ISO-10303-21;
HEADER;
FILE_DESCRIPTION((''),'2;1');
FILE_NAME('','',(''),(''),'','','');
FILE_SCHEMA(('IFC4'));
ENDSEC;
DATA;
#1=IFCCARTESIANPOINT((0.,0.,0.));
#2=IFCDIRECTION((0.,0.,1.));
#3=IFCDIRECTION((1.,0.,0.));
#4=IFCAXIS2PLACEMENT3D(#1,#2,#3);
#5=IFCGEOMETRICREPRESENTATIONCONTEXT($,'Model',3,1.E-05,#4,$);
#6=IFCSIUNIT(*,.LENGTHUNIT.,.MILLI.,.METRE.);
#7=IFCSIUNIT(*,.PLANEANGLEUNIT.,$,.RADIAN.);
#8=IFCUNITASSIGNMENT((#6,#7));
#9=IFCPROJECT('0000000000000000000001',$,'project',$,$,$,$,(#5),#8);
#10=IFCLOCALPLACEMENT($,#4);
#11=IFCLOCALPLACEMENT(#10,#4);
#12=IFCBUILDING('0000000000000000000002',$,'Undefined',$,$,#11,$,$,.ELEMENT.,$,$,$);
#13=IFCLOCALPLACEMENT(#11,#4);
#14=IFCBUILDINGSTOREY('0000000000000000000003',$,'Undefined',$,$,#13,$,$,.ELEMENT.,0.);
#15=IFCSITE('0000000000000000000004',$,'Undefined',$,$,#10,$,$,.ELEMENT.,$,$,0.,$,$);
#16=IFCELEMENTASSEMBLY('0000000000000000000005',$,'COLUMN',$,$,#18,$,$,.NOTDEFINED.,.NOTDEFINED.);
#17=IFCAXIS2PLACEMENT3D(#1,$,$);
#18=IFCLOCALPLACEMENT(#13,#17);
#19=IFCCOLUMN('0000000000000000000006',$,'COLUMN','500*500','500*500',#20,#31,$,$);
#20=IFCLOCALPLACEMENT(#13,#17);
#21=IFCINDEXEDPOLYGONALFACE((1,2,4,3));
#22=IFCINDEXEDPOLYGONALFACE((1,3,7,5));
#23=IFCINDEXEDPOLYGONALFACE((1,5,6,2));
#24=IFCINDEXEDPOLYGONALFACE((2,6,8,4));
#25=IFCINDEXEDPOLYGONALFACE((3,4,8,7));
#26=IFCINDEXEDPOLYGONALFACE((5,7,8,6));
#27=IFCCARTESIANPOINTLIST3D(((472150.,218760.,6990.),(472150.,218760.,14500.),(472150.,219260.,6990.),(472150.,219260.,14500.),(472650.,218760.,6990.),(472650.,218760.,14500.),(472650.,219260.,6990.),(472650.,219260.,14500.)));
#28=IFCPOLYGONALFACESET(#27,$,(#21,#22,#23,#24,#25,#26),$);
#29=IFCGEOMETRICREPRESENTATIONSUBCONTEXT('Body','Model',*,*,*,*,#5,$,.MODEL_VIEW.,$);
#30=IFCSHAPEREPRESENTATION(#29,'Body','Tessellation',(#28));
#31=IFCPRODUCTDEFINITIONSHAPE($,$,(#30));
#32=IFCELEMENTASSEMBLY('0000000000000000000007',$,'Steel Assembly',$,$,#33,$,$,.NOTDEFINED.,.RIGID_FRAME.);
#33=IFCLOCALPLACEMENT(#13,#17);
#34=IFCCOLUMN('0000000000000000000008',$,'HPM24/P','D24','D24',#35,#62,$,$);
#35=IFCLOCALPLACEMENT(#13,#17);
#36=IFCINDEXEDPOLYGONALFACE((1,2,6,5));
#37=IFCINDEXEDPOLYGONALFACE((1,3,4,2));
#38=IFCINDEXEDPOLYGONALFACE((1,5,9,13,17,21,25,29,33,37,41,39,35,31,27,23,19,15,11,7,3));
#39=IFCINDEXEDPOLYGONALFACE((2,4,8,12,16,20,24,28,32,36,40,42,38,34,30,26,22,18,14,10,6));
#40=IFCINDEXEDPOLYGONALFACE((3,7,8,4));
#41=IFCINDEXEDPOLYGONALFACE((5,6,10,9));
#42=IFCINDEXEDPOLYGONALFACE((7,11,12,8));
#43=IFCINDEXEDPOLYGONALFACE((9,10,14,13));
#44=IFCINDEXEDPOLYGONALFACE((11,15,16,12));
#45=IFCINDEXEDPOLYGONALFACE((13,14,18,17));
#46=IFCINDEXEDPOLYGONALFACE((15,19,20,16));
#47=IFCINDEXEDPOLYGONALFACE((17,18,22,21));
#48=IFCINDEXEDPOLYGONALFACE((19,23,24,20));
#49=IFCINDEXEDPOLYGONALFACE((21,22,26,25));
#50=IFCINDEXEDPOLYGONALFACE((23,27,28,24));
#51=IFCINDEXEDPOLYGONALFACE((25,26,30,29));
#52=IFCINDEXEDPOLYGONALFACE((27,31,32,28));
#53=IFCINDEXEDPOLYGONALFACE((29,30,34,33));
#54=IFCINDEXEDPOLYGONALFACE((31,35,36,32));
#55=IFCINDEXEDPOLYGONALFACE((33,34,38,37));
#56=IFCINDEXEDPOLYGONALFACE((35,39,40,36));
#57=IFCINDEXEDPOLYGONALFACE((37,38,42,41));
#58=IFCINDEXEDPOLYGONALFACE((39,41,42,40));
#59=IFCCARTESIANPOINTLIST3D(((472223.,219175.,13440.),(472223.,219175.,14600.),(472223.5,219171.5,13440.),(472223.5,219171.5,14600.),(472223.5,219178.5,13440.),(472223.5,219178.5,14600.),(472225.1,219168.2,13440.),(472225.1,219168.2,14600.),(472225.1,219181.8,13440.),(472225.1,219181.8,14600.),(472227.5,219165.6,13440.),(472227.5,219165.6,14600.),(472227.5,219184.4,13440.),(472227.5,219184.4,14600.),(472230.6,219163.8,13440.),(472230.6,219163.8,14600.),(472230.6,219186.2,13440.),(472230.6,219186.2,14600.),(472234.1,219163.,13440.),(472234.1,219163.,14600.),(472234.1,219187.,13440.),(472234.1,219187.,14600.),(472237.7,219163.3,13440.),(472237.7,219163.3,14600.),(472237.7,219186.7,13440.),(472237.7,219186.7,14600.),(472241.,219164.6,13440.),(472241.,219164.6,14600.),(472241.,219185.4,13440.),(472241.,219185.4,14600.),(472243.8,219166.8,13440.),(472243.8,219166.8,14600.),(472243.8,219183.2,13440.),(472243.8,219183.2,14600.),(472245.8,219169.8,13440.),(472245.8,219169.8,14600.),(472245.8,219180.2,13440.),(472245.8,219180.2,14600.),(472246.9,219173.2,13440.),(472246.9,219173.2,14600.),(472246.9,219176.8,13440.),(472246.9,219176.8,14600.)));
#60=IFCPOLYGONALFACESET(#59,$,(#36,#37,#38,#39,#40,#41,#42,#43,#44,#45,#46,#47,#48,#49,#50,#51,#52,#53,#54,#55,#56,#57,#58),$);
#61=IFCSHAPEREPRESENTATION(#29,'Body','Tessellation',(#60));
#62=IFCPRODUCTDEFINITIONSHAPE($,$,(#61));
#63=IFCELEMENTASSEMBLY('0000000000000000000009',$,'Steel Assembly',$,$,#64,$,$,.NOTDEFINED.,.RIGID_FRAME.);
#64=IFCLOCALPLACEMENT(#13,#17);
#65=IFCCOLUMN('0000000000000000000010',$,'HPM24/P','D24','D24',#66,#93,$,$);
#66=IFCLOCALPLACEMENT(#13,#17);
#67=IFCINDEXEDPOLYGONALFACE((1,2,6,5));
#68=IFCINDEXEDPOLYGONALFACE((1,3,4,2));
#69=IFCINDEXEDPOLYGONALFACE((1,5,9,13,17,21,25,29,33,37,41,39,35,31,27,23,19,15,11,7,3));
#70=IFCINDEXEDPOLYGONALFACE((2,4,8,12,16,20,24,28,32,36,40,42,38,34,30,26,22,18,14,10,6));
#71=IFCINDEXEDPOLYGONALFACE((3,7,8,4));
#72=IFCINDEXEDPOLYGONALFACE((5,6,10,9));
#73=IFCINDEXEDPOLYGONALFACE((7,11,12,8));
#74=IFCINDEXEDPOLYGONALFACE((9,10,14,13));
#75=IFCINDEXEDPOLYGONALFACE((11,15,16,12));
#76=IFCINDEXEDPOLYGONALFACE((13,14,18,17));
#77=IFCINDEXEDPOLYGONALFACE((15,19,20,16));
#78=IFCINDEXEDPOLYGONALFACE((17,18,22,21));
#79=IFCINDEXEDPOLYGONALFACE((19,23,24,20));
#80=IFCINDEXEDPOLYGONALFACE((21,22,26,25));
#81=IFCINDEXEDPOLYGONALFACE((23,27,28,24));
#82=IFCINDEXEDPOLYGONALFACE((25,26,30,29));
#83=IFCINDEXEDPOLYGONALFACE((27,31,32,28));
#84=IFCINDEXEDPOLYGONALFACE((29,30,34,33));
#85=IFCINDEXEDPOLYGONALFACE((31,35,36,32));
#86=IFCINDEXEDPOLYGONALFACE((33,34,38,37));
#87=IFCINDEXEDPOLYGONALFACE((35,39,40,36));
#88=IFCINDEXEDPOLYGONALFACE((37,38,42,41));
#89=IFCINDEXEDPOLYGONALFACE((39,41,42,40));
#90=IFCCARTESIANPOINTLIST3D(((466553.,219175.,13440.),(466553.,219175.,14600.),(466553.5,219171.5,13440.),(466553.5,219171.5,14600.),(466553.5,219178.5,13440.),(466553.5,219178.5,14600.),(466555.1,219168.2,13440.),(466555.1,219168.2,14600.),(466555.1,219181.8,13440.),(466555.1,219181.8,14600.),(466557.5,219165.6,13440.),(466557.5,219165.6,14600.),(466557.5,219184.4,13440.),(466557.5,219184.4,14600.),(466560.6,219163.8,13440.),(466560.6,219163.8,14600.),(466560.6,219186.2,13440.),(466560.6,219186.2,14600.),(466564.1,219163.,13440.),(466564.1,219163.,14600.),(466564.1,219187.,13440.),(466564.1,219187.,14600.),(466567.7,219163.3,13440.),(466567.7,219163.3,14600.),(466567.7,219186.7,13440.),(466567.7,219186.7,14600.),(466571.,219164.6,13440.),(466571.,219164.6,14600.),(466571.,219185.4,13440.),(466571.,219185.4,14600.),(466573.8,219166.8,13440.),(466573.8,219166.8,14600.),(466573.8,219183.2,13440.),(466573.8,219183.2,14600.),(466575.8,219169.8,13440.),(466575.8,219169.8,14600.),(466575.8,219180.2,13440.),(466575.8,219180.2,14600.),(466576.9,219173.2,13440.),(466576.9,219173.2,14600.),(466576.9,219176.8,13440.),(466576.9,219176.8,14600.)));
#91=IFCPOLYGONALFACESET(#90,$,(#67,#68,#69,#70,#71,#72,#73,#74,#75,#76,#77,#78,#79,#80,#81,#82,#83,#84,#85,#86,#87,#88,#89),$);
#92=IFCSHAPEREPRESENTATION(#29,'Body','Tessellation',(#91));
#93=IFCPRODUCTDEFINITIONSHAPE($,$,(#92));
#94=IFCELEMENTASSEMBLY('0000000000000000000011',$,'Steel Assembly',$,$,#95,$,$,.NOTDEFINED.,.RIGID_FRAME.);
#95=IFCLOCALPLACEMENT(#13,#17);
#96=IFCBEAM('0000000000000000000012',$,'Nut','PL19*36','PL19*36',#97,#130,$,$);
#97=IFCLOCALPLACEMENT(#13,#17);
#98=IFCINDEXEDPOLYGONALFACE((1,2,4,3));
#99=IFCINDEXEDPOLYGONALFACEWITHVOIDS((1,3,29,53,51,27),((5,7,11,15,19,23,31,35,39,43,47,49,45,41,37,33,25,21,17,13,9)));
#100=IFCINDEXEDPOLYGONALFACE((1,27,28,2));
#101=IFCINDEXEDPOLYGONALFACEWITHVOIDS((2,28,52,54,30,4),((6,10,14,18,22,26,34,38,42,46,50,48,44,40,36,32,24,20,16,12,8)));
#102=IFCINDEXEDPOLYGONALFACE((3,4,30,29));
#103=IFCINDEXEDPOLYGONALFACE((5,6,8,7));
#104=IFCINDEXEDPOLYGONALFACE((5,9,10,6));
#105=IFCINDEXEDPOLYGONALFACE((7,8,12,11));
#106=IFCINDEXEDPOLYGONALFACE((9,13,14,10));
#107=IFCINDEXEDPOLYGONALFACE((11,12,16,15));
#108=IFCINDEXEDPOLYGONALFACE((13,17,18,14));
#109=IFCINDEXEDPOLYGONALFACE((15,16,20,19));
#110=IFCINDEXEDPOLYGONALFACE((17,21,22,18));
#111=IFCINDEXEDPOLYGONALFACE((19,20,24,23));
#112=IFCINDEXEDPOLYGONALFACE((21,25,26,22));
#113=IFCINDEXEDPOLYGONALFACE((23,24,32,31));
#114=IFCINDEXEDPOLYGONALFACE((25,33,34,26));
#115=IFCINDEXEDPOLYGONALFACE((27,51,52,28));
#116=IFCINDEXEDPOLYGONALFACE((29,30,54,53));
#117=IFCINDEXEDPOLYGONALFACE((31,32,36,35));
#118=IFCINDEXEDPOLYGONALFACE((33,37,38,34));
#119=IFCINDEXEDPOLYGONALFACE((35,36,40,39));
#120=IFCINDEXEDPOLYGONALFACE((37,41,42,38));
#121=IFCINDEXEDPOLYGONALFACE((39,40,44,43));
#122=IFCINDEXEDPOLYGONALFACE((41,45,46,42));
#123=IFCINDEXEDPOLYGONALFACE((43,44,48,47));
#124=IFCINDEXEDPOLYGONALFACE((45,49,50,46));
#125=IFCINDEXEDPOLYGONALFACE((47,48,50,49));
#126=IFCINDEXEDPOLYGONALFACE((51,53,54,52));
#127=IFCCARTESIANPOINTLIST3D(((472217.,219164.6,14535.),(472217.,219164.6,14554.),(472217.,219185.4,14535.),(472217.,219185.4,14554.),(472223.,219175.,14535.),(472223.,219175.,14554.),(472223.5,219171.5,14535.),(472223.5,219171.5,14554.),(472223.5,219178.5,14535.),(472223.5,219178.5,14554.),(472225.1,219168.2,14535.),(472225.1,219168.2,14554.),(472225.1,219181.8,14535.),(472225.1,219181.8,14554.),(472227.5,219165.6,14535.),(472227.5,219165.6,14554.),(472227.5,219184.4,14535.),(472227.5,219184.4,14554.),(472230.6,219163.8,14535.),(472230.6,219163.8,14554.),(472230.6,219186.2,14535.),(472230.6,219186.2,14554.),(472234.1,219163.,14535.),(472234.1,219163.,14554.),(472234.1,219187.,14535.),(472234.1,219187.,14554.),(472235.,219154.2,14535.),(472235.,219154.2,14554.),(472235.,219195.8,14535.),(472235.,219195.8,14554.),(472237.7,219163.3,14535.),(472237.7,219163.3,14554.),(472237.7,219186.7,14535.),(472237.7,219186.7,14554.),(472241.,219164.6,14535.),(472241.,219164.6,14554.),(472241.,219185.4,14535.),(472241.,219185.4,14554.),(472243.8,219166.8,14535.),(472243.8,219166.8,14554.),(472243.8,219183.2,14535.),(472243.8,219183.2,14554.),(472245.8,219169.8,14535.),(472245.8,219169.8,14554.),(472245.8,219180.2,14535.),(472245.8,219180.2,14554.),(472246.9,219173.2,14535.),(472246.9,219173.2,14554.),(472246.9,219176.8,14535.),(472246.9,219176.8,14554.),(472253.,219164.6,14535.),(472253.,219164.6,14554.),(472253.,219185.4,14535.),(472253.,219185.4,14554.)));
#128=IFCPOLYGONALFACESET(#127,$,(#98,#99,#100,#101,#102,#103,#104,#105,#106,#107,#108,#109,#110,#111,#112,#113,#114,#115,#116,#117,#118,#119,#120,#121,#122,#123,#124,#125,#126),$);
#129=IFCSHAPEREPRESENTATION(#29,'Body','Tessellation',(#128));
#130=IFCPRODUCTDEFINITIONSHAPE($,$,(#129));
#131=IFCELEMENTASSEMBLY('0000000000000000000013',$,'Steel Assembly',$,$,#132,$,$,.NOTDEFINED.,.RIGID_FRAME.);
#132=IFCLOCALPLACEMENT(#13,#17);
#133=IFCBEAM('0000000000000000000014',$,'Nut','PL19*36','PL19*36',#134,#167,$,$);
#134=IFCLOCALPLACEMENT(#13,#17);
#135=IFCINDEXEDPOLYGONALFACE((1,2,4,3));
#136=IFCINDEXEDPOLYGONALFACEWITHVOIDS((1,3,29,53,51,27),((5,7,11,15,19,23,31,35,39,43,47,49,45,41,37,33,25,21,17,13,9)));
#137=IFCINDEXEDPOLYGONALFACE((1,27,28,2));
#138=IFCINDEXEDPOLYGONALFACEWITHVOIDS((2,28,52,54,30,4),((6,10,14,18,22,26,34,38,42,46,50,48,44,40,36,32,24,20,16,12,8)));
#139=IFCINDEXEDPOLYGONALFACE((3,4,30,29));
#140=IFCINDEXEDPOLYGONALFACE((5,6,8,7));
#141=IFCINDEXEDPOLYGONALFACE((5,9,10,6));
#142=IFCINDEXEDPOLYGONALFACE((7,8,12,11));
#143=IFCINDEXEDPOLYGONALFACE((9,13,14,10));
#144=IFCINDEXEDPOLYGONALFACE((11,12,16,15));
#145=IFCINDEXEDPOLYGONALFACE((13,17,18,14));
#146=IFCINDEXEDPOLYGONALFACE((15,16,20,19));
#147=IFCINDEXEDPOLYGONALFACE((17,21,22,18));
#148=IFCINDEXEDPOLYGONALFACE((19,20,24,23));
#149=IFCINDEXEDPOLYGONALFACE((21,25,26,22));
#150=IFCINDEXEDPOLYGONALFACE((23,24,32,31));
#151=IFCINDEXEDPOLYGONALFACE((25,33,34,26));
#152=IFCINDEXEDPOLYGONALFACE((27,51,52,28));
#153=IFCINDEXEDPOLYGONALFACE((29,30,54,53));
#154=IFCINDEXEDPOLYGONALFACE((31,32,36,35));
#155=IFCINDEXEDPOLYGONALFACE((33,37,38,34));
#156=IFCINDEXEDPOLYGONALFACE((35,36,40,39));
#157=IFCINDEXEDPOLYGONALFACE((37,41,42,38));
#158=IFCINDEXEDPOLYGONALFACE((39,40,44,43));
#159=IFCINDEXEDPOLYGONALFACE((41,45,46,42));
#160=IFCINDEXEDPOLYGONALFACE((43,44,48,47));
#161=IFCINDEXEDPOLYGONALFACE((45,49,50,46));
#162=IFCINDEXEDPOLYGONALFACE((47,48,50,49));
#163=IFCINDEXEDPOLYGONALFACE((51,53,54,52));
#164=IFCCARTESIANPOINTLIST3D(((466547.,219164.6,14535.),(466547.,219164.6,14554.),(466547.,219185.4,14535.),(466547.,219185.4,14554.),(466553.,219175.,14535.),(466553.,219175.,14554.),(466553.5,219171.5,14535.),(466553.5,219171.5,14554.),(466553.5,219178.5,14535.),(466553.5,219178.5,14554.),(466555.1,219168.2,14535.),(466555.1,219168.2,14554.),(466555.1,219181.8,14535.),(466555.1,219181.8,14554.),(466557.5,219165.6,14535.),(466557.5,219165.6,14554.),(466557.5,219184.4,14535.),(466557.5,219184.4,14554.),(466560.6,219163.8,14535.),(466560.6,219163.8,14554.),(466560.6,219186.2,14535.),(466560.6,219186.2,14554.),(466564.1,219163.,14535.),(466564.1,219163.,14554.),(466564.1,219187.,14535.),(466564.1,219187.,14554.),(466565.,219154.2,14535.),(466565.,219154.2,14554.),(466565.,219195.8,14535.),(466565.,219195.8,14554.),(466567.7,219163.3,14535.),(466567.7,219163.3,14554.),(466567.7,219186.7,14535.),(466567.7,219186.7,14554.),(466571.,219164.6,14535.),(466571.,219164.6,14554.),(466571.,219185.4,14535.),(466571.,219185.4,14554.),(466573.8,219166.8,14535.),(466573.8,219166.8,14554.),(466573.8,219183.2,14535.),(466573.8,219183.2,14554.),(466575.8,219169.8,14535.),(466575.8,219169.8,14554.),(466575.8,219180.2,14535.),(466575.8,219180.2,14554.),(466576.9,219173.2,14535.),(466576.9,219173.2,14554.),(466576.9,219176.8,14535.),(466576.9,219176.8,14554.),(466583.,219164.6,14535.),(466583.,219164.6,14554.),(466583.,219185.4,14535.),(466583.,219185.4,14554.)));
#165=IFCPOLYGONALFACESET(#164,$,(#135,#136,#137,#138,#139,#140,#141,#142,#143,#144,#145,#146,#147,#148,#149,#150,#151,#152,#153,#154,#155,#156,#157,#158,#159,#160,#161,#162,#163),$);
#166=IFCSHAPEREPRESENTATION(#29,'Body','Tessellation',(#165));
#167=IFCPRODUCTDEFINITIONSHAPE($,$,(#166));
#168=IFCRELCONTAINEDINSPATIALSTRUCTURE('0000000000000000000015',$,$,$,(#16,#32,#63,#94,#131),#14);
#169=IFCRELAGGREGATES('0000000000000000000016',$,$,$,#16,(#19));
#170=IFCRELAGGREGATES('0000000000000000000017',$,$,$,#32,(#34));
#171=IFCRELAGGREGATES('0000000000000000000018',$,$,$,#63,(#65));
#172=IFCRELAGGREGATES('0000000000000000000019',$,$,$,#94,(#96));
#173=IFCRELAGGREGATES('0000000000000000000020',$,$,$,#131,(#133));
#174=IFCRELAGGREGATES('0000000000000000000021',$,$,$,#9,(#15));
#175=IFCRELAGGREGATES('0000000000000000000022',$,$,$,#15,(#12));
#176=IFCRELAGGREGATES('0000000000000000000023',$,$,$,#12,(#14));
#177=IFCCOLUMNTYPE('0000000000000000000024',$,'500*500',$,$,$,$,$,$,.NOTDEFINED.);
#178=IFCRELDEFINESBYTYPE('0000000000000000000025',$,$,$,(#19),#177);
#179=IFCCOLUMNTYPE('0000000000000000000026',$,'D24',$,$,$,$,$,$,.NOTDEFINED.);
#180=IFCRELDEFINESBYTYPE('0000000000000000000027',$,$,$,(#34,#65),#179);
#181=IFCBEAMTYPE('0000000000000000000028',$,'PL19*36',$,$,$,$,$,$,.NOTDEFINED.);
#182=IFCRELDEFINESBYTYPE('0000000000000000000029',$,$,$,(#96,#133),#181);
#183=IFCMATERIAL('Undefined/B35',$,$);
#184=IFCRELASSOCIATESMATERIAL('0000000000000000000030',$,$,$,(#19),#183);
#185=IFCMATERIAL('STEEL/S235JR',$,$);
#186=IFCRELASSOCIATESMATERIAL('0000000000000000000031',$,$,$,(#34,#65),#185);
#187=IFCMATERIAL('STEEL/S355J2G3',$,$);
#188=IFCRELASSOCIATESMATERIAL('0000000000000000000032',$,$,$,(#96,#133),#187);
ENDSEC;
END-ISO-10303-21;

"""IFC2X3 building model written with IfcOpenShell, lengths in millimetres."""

from ifc_helpers import new_model, si_unit, frame, origin_with_axes, origin_2d_with_axis, place, context, subcontext, project, spatial, rectangle, circle, extrude, boolean, halfspace, material, type_object, element, aggregate, save


model = new_model("IFC2X3")

# Units and contexts
model_context = context("Model", 3, precision=1e-05, world=origin_with_axes())
body_context = subcontext(model_context, "Body", "Model", "MODEL_VIEW")
ifc_project = project(units=[si_unit("LENGTHUNIT", "METRE", prefix="MILLI"), si_unit("PLANEANGLEUNIT", "RADIAN")], contexts=[model_context])

# Site, building, storey
site_placement = place(None, origin_with_axes())
site = spatial("IfcSite", under=ifc_project, at=site_placement, Name="Undefined", CompositionType="ELEMENT", RefElevation=0.0)
building_placement = place(site_placement, origin_with_axes())
building = spatial("IfcBuilding", under=site, at=building_placement, Name="Undefined", CompositionType="ELEMENT")
storey_placement = place(building_placement, origin_with_axes())
storey = spatial("IfcBuildingStorey", under=building, at=storey_placement, Name="Undefined", CompositionType="ELEMENT", Elevation=0.0)

# Element assemblies, columns
assembly_1_placement = place(storey_placement, origin_with_axes())
assembly_1 = element("IfcElementAssembly", 1, at=assembly_1_placement, inside=storey, Name="COLUMN", AssemblyPlace="NOTDEFINED", PredefinedType="NOTDEFINED")
ifc_material_1 = material(Name="Undefined/B35")
column_type_1 = type_object("IfcColumnType", Name="500*500", PredefinedType="NOTDEFINED")
column_1_placement = place(assembly_1_placement, frame((472400.0, 219010.0, 6990.0), z_axis=(0.0, 0.0, 1.0), x_axis=(1.0, 0.0, 0.0)))
column_1 = element("IfcColumn", 2, at=column_1_placement, type_object=column_type_1, material=ifc_material_1, Name="COLUMN", Description="500*500", ObjectType="500*500", context=body_context, shape_type="SweptSolid", body=[
    extrude(rectangle(XDim=500.0, YDim=500.0, at=origin_2d_with_axis()), frame((0.0, 0.0, 7510.0), z_axis=(0.0, 0.0, -1.0), x_axis=(-1.0, 0.0, 0.0)), (0.0, 0.0, 1.0), 7510.0),
])
aggregate(assembly_1, [column_1])
assembly_2_placement = place(storey_placement, origin_with_axes())
assembly_2 = element("IfcElementAssembly", 3, at=assembly_2_placement, inside=storey, Name="Steel Assembly", AssemblyPlace="NOTDEFINED", PredefinedType="RIGID_FRAME")
ifc_material_2 = material(Name="STEEL/S235JR")
column_type_2 = type_object("IfcColumnType", Name="D24", PredefinedType="NOTDEFINED")
column_2_placement = place(assembly_2_placement, frame((472235.0, 219175.0, 13440.0), z_axis=(0.0, 0.0, 1.0), x_axis=(1.0, 0.0, 0.0)))
column_2 = element("IfcColumn", 4, at=column_2_placement, type_object=column_type_2, material=ifc_material_2, Name="HPM24/P", Description="D24", ObjectType="D24", context=body_context, shape_type="SweptSolid", body=[
    extrude(circle(Radius=12.0, at=origin_2d_with_axis()), frame((0.0, 0.0, 1160.0), z_axis=(0.0, 0.0, -1.0), x_axis=(-1.0, 0.0, 0.0)), (0.0, 0.0, 1.0), 1160.0),
])
aggregate(assembly_2, [column_2])
assembly_3_placement = place(storey_placement, origin_with_axes())
assembly_3 = element("IfcElementAssembly", 5, at=assembly_3_placement, inside=storey, Name="Steel Assembly", AssemblyPlace="NOTDEFINED", PredefinedType="RIGID_FRAME")
column_3_placement = place(assembly_3_placement, frame((466565.0, 219175.0, 13440.0), z_axis=(0.0, 0.0, 1.0), x_axis=(1.0, 0.0, 0.0)))
column_3 = element("IfcColumn", 6, at=column_3_placement, type_object=column_type_2, material=ifc_material_2, Name="HPM24/P", Description="D24", ObjectType="D24", context=body_context, shape_type="SweptSolid", body=[
    extrude(circle(Radius=12.0, at=origin_2d_with_axis()), frame((0.0, 0.0, 1160.0), z_axis=(0.0, 0.0, -1.0), x_axis=(-1.0, 0.0, 0.0)), (0.0, 0.0, 1.0), 1160.0),
])
aggregate(assembly_3, [column_3])

# Element assemblies, beams
assembly_4_placement = place(storey_placement, origin_with_axes())
assembly_4 = element("IfcElementAssembly", 7, at=assembly_4_placement, inside=storey, Name="Steel Assembly", AssemblyPlace="NOTDEFINED", PredefinedType="RIGID_FRAME")
ifc_material_3 = material(Name="STEEL/S355J2G3")
beam_type_1 = type_object("IfcBeamType", Name="PL19*36", PredefinedType="NOTDEFINED")
beam_1_placement = place(assembly_4_placement, frame((472235.0, 219195.8, 14544.5), z_axis=(-1.0, 0.0, 0.0), x_axis=(0.0, -1.0, 0.0)))
beam_1 = element("IfcBeam", 8, at=beam_1_placement, type_object=beam_type_1, material=ifc_material_3, Name="Nut", Description="PL19*36", ObjectType="PL19*36", context=body_context, shape_type="CSG", body=[
    boolean("DIFFERENCE", boolean("DIFFERENCE", boolean("DIFFERENCE", boolean("DIFFERENCE", boolean("DIFFERENCE", extrude(rectangle(XDim=19.0, YDim=36.0, at=origin_2d_with_axis()), frame((41.6, 0.0, 0.0), z_axis=(-1.0, 0.0, 0.0), x_axis=(0.0, -1.0, 0.0)), (0.0, 0.0, 1.0), 41.6), extrude(circle(Radius=12.0, at=origin_2d_with_axis()), frame((20.8, -9.5, 0.0), z_axis=(0.0, 1.0, 0.0), x_axis=(0.0, 0.0, 1.0)), (0.0, 0.0, 1.0), 19.0)), halfspace(frame((31.2, -9.5, -18.0), z_axis=(0.865865, 0.0, -0.500278), x_axis=(0.500278, 0.0, 0.865865)), False)), halfspace(frame((52.0, -9.5, -18.0), z_axis=(0.865865, 0.0, 0.500278), x_axis=(-0.500278, 0.0, 0.865865)), False)), halfspace(frame((-10.4, 9.5, -18.0), z_axis=(-0.865865, 0.0, 0.500278), x_axis=(0.500278, 0.0, 0.865865)), False)), halfspace(frame((10.4, 9.5, -18.0), z_axis=(-0.865865, 0.0, -0.500278), x_axis=(-0.500278, 0.0, 0.865865)), False)),
])
aggregate(assembly_4, [beam_1])
assembly_5_placement = place(storey_placement, origin_with_axes())
assembly_5 = element("IfcElementAssembly", 9, at=assembly_5_placement, inside=storey, Name="Steel Assembly", AssemblyPlace="NOTDEFINED", PredefinedType="RIGID_FRAME")
beam_2_placement = place(assembly_5_placement, frame((466565.0, 219195.8, 14544.5), z_axis=(-1.0, 0.0, 0.0), x_axis=(0.0, -1.0, 0.0)))
beam_2 = element("IfcBeam", 10, at=beam_2_placement, type_object=beam_type_1, material=ifc_material_3, Name="Nut", Description="PL19*36", ObjectType="PL19*36", context=body_context, shape_type="CSG", body=[
    boolean("DIFFERENCE", boolean("DIFFERENCE", boolean("DIFFERENCE", boolean("DIFFERENCE", boolean("DIFFERENCE", extrude(rectangle(XDim=19.0, YDim=36.0, at=origin_2d_with_axis()), frame((41.6, 0.0, 0.0), z_axis=(-1.0, 0.0, 0.0), x_axis=(0.0, -1.0, 0.0)), (0.0, 0.0, 1.0), 41.6), extrude(circle(Radius=12.0, at=origin_2d_with_axis()), frame((20.8, -9.5, 0.0), z_axis=(0.0, 1.0, 0.0), x_axis=(0.0, 0.0, 1.0)), (0.0, 0.0, 1.0), 19.0)), halfspace(frame((31.2, -9.5, -18.0), z_axis=(0.865865, 0.0, -0.500278), x_axis=(0.500278, 0.0, 0.865865)), False)), halfspace(frame((52.0, -9.5, -18.0), z_axis=(0.865865, 0.0, 0.500278), x_axis=(-0.500278, 0.0, 0.865865)), False)), halfspace(frame((-10.4, 9.5, -18.0), z_axis=(-0.865865, 0.0, 0.500278), x_axis=(0.500278, 0.0, 0.865865)), False)), halfspace(frame((10.4, 9.5, -18.0), z_axis=(-0.865865, 0.0, -0.500278), x_axis=(-0.500278, 0.0, 0.865865)), False)),
])
aggregate(assembly_5, [beam_2])

save(model, "model.ifc")
